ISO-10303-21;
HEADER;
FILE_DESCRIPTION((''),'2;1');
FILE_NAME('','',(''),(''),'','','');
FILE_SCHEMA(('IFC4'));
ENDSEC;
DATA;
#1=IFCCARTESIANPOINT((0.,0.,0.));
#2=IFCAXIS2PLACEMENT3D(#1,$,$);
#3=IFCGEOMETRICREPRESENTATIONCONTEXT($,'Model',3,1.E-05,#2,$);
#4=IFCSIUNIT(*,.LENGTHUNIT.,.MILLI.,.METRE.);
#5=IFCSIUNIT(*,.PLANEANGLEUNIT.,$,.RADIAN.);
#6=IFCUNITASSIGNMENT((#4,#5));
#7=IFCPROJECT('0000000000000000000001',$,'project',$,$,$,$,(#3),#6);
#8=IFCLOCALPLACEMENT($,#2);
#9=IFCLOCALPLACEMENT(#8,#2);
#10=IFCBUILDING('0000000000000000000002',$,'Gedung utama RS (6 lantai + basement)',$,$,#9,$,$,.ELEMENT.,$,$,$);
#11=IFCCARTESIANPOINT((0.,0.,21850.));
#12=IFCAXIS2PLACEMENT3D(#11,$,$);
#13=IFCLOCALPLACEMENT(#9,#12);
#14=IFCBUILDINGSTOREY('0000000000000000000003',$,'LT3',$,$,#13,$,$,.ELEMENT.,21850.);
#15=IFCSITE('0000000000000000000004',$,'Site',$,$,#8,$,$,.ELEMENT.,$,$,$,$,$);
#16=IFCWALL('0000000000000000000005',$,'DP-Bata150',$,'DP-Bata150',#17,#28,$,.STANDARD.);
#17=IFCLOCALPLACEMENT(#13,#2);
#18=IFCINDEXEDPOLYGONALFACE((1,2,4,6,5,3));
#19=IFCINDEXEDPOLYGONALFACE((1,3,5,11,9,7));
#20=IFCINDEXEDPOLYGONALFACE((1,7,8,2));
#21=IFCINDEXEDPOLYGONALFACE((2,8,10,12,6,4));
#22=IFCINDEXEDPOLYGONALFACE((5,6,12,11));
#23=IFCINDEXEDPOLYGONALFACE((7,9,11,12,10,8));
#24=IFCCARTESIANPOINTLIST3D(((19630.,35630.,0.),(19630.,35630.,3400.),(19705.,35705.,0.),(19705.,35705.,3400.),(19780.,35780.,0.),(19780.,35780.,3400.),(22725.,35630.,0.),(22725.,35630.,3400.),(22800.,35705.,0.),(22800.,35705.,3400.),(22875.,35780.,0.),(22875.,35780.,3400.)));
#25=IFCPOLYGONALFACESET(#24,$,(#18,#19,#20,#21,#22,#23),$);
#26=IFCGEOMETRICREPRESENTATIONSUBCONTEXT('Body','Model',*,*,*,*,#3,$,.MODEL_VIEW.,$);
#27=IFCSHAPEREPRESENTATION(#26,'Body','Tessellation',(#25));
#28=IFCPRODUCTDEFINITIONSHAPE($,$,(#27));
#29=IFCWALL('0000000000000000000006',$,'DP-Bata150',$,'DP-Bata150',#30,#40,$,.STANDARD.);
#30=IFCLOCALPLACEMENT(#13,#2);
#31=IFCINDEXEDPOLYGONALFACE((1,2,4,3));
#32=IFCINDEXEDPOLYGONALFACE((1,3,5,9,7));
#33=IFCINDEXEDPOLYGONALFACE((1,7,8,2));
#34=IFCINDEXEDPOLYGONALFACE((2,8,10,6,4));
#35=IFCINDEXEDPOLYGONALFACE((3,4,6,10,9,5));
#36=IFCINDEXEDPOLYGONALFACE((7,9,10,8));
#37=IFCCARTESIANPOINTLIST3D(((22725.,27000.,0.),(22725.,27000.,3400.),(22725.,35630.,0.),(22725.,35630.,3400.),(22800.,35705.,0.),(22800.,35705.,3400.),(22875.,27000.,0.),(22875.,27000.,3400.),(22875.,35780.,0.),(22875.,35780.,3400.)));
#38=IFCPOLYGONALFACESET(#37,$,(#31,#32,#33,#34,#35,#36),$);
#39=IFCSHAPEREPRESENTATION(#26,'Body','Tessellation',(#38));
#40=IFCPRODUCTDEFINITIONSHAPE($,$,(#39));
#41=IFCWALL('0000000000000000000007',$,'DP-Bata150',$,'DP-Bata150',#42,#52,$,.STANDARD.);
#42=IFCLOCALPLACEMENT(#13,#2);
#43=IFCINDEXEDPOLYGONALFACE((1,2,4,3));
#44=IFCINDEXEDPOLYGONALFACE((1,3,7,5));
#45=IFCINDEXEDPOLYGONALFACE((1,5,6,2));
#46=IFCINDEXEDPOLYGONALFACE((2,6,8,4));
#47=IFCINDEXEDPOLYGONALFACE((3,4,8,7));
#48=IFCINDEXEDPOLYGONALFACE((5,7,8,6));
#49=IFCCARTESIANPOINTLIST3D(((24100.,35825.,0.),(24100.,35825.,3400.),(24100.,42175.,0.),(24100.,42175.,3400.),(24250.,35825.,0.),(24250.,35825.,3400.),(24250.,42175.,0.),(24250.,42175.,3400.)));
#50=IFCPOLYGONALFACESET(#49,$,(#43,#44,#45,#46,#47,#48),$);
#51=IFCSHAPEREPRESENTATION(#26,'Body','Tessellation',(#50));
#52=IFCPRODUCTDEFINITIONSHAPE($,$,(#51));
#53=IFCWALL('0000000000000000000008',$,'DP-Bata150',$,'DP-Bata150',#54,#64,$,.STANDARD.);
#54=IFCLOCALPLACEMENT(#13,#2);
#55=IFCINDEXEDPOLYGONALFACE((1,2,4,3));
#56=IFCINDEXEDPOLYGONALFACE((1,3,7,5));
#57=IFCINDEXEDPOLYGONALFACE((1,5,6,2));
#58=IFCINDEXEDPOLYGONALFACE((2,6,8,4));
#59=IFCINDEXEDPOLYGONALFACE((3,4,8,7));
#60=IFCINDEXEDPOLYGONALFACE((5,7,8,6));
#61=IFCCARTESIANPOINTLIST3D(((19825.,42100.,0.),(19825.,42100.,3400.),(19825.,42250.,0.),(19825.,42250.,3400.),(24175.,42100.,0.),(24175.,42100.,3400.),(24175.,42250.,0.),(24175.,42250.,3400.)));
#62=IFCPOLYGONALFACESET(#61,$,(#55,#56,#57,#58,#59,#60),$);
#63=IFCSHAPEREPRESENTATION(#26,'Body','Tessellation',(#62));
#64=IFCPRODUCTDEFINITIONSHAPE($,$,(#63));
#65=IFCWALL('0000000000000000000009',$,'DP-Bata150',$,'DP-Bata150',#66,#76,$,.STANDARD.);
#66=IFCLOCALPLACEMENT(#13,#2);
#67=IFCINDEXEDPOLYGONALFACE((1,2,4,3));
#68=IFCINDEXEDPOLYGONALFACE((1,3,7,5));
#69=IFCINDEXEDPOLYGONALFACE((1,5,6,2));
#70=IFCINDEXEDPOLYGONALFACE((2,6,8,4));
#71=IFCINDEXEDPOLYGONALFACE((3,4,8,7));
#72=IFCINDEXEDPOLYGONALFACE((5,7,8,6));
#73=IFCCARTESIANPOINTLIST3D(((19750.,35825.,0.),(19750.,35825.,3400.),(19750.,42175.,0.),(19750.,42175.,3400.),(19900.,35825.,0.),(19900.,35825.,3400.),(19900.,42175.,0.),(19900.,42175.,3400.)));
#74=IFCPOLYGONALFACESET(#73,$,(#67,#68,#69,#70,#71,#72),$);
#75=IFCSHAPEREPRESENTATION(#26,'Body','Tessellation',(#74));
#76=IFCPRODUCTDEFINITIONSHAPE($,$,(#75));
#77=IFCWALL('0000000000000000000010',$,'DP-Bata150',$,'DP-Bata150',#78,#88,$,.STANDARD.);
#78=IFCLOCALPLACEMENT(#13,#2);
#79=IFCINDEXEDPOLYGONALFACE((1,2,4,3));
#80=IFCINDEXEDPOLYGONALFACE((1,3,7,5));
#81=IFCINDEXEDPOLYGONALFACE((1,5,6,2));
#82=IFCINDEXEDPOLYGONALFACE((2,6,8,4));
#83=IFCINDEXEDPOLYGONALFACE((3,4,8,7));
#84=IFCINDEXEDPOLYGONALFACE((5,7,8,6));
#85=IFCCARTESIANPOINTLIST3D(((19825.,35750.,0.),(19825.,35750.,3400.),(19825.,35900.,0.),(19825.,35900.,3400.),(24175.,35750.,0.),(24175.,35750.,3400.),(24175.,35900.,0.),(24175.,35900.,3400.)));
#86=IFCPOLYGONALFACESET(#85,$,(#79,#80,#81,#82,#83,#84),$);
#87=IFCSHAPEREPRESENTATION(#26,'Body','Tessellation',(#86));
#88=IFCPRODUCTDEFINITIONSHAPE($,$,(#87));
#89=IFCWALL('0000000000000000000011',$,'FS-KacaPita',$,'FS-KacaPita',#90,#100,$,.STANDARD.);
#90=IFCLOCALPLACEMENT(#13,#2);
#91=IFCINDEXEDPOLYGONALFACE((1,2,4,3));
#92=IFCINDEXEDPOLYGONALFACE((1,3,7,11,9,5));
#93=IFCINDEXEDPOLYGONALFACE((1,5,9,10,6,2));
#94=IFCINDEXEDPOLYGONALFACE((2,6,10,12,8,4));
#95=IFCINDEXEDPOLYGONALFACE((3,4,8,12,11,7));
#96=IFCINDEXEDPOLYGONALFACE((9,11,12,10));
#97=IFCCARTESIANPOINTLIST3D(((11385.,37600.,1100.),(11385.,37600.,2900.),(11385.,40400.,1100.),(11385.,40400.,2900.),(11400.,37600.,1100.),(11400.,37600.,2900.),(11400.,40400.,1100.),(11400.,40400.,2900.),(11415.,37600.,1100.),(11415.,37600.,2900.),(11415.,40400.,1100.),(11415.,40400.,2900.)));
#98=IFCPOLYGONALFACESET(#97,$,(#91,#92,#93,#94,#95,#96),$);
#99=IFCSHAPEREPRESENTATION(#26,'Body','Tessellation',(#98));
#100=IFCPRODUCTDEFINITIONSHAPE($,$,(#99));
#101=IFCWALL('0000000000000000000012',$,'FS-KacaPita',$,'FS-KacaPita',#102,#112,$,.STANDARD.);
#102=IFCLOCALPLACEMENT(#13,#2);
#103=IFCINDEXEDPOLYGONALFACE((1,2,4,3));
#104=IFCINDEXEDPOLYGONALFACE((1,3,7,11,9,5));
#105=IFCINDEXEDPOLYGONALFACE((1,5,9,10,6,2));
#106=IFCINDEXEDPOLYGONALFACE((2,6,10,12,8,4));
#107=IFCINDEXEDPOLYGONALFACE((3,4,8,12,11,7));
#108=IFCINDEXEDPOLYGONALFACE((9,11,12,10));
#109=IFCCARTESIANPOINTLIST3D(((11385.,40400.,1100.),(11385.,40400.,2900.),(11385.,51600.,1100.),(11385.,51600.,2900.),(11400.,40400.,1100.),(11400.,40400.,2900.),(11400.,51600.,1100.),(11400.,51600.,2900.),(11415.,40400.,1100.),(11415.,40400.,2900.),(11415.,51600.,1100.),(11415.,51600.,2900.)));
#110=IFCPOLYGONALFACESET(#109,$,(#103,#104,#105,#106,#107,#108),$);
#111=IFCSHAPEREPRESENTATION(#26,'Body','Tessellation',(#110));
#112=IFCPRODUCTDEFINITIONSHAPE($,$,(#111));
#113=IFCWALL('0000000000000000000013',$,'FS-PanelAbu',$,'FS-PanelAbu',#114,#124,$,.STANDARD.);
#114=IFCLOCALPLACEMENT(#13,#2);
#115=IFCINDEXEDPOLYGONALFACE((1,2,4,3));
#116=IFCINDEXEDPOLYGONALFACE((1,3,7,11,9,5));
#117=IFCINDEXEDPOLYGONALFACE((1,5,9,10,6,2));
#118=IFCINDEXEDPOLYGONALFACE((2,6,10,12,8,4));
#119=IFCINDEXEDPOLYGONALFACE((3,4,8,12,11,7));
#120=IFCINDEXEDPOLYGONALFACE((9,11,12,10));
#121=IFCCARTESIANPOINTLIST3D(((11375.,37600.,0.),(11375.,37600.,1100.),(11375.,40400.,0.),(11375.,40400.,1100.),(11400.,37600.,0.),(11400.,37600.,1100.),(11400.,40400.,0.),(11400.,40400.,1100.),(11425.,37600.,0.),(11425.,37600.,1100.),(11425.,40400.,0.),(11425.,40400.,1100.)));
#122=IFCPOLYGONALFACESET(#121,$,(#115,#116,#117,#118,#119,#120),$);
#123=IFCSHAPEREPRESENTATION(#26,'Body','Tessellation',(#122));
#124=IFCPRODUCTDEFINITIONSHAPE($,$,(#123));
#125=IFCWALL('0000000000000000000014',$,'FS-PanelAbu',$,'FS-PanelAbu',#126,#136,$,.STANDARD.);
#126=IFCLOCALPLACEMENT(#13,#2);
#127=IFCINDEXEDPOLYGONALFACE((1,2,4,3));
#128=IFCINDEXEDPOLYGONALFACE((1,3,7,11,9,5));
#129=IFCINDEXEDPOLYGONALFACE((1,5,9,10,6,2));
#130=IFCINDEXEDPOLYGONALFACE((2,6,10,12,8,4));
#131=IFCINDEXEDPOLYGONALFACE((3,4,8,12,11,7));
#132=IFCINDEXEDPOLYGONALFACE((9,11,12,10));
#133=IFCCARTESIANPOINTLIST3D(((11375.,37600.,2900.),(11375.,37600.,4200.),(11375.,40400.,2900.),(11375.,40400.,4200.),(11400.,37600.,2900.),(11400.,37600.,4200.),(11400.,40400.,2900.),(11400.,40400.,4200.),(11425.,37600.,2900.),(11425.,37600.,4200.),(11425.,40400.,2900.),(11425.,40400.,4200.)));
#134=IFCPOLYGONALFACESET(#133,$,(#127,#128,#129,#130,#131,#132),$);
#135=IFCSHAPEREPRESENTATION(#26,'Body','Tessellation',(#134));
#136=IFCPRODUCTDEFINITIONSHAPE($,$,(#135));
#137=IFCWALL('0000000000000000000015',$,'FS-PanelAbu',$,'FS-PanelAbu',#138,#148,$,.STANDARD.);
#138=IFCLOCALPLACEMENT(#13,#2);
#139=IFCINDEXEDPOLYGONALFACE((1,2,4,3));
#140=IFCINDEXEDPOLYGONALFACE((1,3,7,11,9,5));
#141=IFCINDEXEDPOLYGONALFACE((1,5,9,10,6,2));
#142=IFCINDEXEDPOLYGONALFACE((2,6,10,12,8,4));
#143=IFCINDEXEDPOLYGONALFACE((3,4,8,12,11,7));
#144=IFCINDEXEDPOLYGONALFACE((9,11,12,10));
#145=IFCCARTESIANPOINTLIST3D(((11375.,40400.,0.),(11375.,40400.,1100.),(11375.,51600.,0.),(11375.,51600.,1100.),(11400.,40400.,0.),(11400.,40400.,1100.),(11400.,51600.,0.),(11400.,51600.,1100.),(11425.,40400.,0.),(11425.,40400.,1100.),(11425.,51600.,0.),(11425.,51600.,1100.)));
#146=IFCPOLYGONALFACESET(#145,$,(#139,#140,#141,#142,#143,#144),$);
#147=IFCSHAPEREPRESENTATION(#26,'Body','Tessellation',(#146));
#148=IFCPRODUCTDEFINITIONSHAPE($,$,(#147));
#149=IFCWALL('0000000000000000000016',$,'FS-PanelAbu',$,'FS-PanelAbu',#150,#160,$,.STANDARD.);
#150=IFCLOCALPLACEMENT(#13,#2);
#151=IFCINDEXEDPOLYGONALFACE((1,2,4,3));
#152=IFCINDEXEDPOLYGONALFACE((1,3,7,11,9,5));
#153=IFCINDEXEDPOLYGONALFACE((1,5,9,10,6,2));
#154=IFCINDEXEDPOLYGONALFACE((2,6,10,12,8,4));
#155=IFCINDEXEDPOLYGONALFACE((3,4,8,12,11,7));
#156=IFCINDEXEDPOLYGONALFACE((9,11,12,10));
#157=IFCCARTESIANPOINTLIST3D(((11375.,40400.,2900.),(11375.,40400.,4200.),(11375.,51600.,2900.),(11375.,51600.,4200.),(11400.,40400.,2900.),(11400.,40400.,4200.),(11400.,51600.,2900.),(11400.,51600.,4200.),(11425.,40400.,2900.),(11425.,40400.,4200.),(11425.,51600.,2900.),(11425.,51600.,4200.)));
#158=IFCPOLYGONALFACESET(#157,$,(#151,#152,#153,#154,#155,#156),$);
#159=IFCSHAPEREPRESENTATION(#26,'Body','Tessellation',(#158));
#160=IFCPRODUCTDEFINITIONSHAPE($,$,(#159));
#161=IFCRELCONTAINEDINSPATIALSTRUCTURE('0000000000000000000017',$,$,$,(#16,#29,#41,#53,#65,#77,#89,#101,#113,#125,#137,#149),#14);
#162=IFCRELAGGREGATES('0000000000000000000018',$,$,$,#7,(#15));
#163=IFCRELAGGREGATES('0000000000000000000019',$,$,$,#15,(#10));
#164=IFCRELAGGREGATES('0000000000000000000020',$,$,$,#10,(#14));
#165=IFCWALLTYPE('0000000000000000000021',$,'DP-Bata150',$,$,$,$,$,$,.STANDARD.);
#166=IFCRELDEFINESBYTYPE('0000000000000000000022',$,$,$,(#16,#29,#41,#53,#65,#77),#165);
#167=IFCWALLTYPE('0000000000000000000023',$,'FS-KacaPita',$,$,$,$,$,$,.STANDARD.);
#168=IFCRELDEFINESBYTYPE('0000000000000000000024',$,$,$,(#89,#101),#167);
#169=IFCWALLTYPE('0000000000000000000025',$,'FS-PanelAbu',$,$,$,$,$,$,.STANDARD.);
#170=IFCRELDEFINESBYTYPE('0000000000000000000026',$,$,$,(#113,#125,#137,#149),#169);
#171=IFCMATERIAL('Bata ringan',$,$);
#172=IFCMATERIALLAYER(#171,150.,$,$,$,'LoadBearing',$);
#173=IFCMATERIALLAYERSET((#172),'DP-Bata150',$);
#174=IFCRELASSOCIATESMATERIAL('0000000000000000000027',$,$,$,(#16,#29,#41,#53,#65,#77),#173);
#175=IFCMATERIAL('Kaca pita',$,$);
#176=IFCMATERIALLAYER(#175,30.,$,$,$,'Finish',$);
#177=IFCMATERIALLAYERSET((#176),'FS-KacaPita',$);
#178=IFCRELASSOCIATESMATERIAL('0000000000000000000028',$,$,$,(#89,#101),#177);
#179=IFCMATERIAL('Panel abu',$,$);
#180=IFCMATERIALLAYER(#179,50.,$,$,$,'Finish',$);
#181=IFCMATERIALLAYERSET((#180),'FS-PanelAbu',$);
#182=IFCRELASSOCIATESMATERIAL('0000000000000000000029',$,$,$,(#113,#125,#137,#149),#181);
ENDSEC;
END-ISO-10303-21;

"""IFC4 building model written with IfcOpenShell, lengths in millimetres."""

from ifc_helpers import new_model, si_unit, frame, origin, place, context, subcontext, project, spatial, polyline, outline, extrude, material, layer, layer_set, layer_usage, type_object, element, save


model = new_model("IFC4")

# Units and contexts
model_context = context("Model", 3, precision=1e-05, world=origin())
body_context = subcontext(model_context, "Body", "Model", "MODEL_VIEW")
ifc_project = project(units=[si_unit("LENGTHUNIT", "METRE", prefix="MILLI"), si_unit("PLANEANGLEUNIT", "RADIAN")], contexts=[model_context])

# Site, building, storey
site_placement = place(None, origin())
site = spatial("IfcSite", under=ifc_project, at=site_placement, Name="Site", CompositionType="ELEMENT")
building_placement = place(site_placement, origin())
building = spatial("IfcBuilding", under=site, at=building_placement, Name="Gedung utama RS (6 lantai + basement)", CompositionType="ELEMENT")
storey_placement = place(building_placement, frame((0.0, 0.0, 21850.0)))
storey = spatial("IfcBuildingStorey", under=building, at=storey_placement, Name="LT3", CompositionType="ELEMENT", Elevation=21850.0)

# Walls
ifc_material_1 = material(Name="Bata ringan")
ifc_layer_1 = layer(ifc_material_1, 150.0, Category="LoadBearing")
ifc_layer_set_1 = layer_set([ifc_layer_1], Name="DP-Bata150")
ifc_layer_usage_1 = layer_usage(ifc_layer_set_1, "AXIS2", "NEGATIVE", 75.0)
wall_type_1 = type_object("IfcWallType", Name="DP-Bata150", PredefinedType="STANDARD")
wall_1_placement = place(storey_placement, frame((19705.0, 35705.0, 0.0), z_axis=(0.0, 0.0, 1.0), x_axis=(1.0, 0.0, 0.0)))
element("IfcWall", 1, at=wall_1_placement, inside=storey, type_object=wall_type_1, material=ifc_layer_usage_1, Name="DP-Bata150", ObjectType="DP-Bata150", PredefinedType="STANDARD", context=body_context, shape_type="SweptSolid", body=[
    extrude(outline(polyline([(-75.0, -75.0), (0.0, 0.0), (75.0, 75.0), (3170.0, 75.0), (3095.0, 0.0), (3020.0, -75.0), (-75.0, -75.0)])), origin(), (0.0, 0.0, 1.0), 3400.0),
])
wall_2_placement = place(storey_placement, frame((22800.0, 35705.0, 0.0), z_axis=(0.0, 0.0, 1.0), x_axis=(0.0, -1.0, 0.0)))
element("IfcWall", 2, at=wall_2_placement, inside=storey, type_object=wall_type_1, material=ifc_layer_usage_1, Name="DP-Bata150", ObjectType="DP-Bata150", PredefinedType="STANDARD", context=body_context, shape_type="SweptSolid", body=[
    extrude(outline(polyline([(75.0, -75.0), (0.0, 0.0), (-75.0, 75.0), (8705.0, 75.0), (8705.0, -75.0), (75.0, -75.0)])), origin(), (0.0, 0.0, 1.0), 3400.0),
])
wall_3_placement = place(storey_placement, frame((24175.0, 35825.0, 0.0), z_axis=(0.0, 0.0, 1.0), x_axis=(0.0, 1.0, 0.0)))
element("IfcWall", 3, at=wall_3_placement, inside=storey, type_object=wall_type_1, material=ifc_layer_usage_1, Name="DP-Bata150", ObjectType="DP-Bata150", PredefinedType="STANDARD", context=body_context, shape_type="SweptSolid", body=[
    extrude(outline(polyline([(0.0, -75.0), (0.0, 75.0), (6350.0, 75.0), (6350.0, -75.0), (0.0, -75.0)])), origin(), (0.0, 0.0, 1.0), 3400.0),
])
wall_4_placement = place(storey_placement, frame((24175.0, 42175.0, 0.0), z_axis=(0.0, 0.0, 1.0), x_axis=(-1.0, 0.0, 0.0)))
element("IfcWall", 4, at=wall_4_placement, inside=storey, type_object=wall_type_1, material=ifc_layer_usage_1, Name="DP-Bata150", ObjectType="DP-Bata150", PredefinedType="STANDARD", context=body_context, shape_type="SweptSolid", body=[
    extrude(outline(polyline([(0.0, -75.0), (0.0, 75.0), (4350.0, 75.0), (4350.0, -75.0), (0.0, -75.0)])), origin(), (0.0, 0.0, 1.0), 3400.0),
])
wall_5_placement = place(storey_placement, frame((19825.0, 42175.0, 0.0), z_axis=(0.0, 0.0, 1.0), x_axis=(0.0, -1.0, 0.0)))
element("IfcWall", 5, at=wall_5_placement, inside=storey, type_object=wall_type_1, material=ifc_layer_usage_1, Name="DP-Bata150", ObjectType="DP-Bata150", PredefinedType="STANDARD", context=body_context, shape_type="SweptSolid", body=[
    extrude(outline(polyline([(0.0, -75.0), (0.0, 75.0), (6350.0, 75.0), (6350.0, -75.0), (0.0, -75.0)])), origin(), (0.0, 0.0, 1.0), 3400.0),
])
wall_6_placement = place(storey_placement, frame((19825.0, 35825.0, 0.0), z_axis=(0.0, 0.0, 1.0), x_axis=(1.0, 0.0, 0.0)))
element("IfcWall", 6, at=wall_6_placement, inside=storey, type_object=wall_type_1, material=ifc_layer_usage_1, Name="DP-Bata150", ObjectType="DP-Bata150", PredefinedType="STANDARD", context=body_context, shape_type="SweptSolid", body=[
    extrude(outline(polyline([(0.0, -75.0), (0.0, 75.0), (4350.0, 75.0), (4350.0, -75.0), (0.0, -75.0)])), origin(), (0.0, 0.0, 1.0), 3400.0),
])
ifc_material_2 = material(Name="Kaca pita")
ifc_layer_2 = layer(ifc_material_2, 30.0, Category="Finish")
ifc_layer_set_2 = layer_set([ifc_layer_2], Name="FS-KacaPita")
ifc_layer_usage_2 = layer_usage(ifc_layer_set_2, "AXIS2", "NEGATIVE", 15.0)
wall_type_2 = type_object("IfcWallType", Name="FS-KacaPita", PredefinedType="STANDARD")
wall_7_placement = place(storey_placement, frame((11400.0, 37600.0, 1100.0), z_axis=(0.0, 0.0, 1.0), x_axis=(0.0, 1.0, 0.0)))
element("IfcWall", 7, at=wall_7_placement, inside=storey, type_object=wall_type_2, material=ifc_layer_usage_2, Name="FS-KacaPita", ObjectType="FS-KacaPita", PredefinedType="STANDARD", context=body_context, shape_type="SweptSolid", body=[
    extrude(outline(polyline([(0.0, -15.0), (0.0, 0.0), (0.0, 15.0), (2800.0, 15.0), (2800.0, 0.0), (2800.0, -15.0), (0.0, -15.0)])), origin(), (0.0, 0.0, 1.0), 1800.0),
])
wall_8_placement = place(storey_placement, frame((11400.0, 40400.0, 1100.0), z_axis=(0.0, 0.0, 1.0), x_axis=(0.0, 1.0, 0.0)))
element("IfcWall", 8, at=wall_8_placement, inside=storey, type_object=wall_type_2, material=ifc_layer_usage_2, Name="FS-KacaPita", ObjectType="FS-KacaPita", PredefinedType="STANDARD", context=body_context, shape_type="SweptSolid", body=[
    extrude(outline(polyline([(0.0, -15.0), (0.0, 0.0), (0.0, 15.0), (11200.0, 15.0), (11200.0, 0.0), (11200.0, -15.0), (0.0, -15.0)])), origin(), (0.0, 0.0, 1.0), 1800.0),
])
ifc_material_3 = material(Name="Panel abu")
ifc_layer_3 = layer(ifc_material_3, 50.0, Category="Finish")
ifc_layer_set_3 = layer_set([ifc_layer_3], Name="FS-PanelAbu")
ifc_layer_usage_3 = layer_usage(ifc_layer_set_3, "AXIS2", "NEGATIVE", 25.0)
wall_type_3 = type_object("IfcWallType", Name="FS-PanelAbu", PredefinedType="STANDARD")
wall_9_placement = place(storey_placement, frame((11400.0, 37600.0, 0.0), z_axis=(0.0, 0.0, 1.0), x_axis=(0.0, 1.0, 0.0)))
element("IfcWall", 9, at=wall_9_placement, inside=storey, type_object=wall_type_3, material=ifc_layer_usage_3, Name="FS-PanelAbu", ObjectType="FS-PanelAbu", PredefinedType="STANDARD", context=body_context, shape_type="SweptSolid", body=[
    extrude(outline(polyline([(0.0, -25.0), (0.0, 0.0), (0.0, 25.0), (2800.0, 25.0), (2800.0, 0.0), (2800.0, -25.0), (0.0, -25.0)])), origin(), (0.0, 0.0, 1.0), 1100.0),
])
wall_10_placement = place(storey_placement, frame((11400.0, 37600.0, 2900.0), z_axis=(0.0, 0.0, 1.0), x_axis=(0.0, 1.0, 0.0)))
element("IfcWall", 10, at=wall_10_placement, inside=storey, type_object=wall_type_3, material=ifc_layer_usage_3, Name="FS-PanelAbu", ObjectType="FS-PanelAbu", PredefinedType="STANDARD", context=body_context, shape_type="SweptSolid", body=[
    extrude(outline(polyline([(0.0, -25.0), (0.0, 0.0), (0.0, 25.0), (2800.0, 25.0), (2800.0, 0.0), (2800.0, -25.0), (0.0, -25.0)])), origin(), (0.0, 0.0, 1.0), 1300.0),
])
wall_11_placement = place(storey_placement, frame((11400.0, 40400.0, 0.0), z_axis=(0.0, 0.0, 1.0), x_axis=(0.0, 1.0, 0.0)))
element("IfcWall", 11, at=wall_11_placement, inside=storey, type_object=wall_type_3, material=ifc_layer_usage_3, Name="FS-PanelAbu", ObjectType="FS-PanelAbu", PredefinedType="STANDARD", context=body_context, shape_type="SweptSolid", body=[
    extrude(outline(polyline([(0.0, -25.0), (0.0, 0.0), (0.0, 25.0), (11200.0, 25.0), (11200.0, 0.0), (11200.0, -25.0), (0.0, -25.0)])), origin(), (0.0, 0.0, 1.0), 1100.0),
])
wall_12_placement = place(storey_placement, frame((11400.0, 40400.0, 2900.0), z_axis=(0.0, 0.0, 1.0), x_axis=(0.0, 1.0, 0.0)))
element("IfcWall", 12, at=wall_12_placement, inside=storey, type_object=wall_type_3, material=ifc_layer_usage_3, Name="FS-PanelAbu", ObjectType="FS-PanelAbu", PredefinedType="STANDARD", context=body_context, shape_type="SweptSolid", body=[
    extrude(outline(polyline([(0.0, -25.0), (0.0, 0.0), (0.0, 25.0), (11200.0, 25.0), (11200.0, 0.0), (11200.0, -25.0), (0.0, -25.0)])), origin(), (0.0, 0.0, 1.0), 1300.0),
])

save(model, "model.ifc")
